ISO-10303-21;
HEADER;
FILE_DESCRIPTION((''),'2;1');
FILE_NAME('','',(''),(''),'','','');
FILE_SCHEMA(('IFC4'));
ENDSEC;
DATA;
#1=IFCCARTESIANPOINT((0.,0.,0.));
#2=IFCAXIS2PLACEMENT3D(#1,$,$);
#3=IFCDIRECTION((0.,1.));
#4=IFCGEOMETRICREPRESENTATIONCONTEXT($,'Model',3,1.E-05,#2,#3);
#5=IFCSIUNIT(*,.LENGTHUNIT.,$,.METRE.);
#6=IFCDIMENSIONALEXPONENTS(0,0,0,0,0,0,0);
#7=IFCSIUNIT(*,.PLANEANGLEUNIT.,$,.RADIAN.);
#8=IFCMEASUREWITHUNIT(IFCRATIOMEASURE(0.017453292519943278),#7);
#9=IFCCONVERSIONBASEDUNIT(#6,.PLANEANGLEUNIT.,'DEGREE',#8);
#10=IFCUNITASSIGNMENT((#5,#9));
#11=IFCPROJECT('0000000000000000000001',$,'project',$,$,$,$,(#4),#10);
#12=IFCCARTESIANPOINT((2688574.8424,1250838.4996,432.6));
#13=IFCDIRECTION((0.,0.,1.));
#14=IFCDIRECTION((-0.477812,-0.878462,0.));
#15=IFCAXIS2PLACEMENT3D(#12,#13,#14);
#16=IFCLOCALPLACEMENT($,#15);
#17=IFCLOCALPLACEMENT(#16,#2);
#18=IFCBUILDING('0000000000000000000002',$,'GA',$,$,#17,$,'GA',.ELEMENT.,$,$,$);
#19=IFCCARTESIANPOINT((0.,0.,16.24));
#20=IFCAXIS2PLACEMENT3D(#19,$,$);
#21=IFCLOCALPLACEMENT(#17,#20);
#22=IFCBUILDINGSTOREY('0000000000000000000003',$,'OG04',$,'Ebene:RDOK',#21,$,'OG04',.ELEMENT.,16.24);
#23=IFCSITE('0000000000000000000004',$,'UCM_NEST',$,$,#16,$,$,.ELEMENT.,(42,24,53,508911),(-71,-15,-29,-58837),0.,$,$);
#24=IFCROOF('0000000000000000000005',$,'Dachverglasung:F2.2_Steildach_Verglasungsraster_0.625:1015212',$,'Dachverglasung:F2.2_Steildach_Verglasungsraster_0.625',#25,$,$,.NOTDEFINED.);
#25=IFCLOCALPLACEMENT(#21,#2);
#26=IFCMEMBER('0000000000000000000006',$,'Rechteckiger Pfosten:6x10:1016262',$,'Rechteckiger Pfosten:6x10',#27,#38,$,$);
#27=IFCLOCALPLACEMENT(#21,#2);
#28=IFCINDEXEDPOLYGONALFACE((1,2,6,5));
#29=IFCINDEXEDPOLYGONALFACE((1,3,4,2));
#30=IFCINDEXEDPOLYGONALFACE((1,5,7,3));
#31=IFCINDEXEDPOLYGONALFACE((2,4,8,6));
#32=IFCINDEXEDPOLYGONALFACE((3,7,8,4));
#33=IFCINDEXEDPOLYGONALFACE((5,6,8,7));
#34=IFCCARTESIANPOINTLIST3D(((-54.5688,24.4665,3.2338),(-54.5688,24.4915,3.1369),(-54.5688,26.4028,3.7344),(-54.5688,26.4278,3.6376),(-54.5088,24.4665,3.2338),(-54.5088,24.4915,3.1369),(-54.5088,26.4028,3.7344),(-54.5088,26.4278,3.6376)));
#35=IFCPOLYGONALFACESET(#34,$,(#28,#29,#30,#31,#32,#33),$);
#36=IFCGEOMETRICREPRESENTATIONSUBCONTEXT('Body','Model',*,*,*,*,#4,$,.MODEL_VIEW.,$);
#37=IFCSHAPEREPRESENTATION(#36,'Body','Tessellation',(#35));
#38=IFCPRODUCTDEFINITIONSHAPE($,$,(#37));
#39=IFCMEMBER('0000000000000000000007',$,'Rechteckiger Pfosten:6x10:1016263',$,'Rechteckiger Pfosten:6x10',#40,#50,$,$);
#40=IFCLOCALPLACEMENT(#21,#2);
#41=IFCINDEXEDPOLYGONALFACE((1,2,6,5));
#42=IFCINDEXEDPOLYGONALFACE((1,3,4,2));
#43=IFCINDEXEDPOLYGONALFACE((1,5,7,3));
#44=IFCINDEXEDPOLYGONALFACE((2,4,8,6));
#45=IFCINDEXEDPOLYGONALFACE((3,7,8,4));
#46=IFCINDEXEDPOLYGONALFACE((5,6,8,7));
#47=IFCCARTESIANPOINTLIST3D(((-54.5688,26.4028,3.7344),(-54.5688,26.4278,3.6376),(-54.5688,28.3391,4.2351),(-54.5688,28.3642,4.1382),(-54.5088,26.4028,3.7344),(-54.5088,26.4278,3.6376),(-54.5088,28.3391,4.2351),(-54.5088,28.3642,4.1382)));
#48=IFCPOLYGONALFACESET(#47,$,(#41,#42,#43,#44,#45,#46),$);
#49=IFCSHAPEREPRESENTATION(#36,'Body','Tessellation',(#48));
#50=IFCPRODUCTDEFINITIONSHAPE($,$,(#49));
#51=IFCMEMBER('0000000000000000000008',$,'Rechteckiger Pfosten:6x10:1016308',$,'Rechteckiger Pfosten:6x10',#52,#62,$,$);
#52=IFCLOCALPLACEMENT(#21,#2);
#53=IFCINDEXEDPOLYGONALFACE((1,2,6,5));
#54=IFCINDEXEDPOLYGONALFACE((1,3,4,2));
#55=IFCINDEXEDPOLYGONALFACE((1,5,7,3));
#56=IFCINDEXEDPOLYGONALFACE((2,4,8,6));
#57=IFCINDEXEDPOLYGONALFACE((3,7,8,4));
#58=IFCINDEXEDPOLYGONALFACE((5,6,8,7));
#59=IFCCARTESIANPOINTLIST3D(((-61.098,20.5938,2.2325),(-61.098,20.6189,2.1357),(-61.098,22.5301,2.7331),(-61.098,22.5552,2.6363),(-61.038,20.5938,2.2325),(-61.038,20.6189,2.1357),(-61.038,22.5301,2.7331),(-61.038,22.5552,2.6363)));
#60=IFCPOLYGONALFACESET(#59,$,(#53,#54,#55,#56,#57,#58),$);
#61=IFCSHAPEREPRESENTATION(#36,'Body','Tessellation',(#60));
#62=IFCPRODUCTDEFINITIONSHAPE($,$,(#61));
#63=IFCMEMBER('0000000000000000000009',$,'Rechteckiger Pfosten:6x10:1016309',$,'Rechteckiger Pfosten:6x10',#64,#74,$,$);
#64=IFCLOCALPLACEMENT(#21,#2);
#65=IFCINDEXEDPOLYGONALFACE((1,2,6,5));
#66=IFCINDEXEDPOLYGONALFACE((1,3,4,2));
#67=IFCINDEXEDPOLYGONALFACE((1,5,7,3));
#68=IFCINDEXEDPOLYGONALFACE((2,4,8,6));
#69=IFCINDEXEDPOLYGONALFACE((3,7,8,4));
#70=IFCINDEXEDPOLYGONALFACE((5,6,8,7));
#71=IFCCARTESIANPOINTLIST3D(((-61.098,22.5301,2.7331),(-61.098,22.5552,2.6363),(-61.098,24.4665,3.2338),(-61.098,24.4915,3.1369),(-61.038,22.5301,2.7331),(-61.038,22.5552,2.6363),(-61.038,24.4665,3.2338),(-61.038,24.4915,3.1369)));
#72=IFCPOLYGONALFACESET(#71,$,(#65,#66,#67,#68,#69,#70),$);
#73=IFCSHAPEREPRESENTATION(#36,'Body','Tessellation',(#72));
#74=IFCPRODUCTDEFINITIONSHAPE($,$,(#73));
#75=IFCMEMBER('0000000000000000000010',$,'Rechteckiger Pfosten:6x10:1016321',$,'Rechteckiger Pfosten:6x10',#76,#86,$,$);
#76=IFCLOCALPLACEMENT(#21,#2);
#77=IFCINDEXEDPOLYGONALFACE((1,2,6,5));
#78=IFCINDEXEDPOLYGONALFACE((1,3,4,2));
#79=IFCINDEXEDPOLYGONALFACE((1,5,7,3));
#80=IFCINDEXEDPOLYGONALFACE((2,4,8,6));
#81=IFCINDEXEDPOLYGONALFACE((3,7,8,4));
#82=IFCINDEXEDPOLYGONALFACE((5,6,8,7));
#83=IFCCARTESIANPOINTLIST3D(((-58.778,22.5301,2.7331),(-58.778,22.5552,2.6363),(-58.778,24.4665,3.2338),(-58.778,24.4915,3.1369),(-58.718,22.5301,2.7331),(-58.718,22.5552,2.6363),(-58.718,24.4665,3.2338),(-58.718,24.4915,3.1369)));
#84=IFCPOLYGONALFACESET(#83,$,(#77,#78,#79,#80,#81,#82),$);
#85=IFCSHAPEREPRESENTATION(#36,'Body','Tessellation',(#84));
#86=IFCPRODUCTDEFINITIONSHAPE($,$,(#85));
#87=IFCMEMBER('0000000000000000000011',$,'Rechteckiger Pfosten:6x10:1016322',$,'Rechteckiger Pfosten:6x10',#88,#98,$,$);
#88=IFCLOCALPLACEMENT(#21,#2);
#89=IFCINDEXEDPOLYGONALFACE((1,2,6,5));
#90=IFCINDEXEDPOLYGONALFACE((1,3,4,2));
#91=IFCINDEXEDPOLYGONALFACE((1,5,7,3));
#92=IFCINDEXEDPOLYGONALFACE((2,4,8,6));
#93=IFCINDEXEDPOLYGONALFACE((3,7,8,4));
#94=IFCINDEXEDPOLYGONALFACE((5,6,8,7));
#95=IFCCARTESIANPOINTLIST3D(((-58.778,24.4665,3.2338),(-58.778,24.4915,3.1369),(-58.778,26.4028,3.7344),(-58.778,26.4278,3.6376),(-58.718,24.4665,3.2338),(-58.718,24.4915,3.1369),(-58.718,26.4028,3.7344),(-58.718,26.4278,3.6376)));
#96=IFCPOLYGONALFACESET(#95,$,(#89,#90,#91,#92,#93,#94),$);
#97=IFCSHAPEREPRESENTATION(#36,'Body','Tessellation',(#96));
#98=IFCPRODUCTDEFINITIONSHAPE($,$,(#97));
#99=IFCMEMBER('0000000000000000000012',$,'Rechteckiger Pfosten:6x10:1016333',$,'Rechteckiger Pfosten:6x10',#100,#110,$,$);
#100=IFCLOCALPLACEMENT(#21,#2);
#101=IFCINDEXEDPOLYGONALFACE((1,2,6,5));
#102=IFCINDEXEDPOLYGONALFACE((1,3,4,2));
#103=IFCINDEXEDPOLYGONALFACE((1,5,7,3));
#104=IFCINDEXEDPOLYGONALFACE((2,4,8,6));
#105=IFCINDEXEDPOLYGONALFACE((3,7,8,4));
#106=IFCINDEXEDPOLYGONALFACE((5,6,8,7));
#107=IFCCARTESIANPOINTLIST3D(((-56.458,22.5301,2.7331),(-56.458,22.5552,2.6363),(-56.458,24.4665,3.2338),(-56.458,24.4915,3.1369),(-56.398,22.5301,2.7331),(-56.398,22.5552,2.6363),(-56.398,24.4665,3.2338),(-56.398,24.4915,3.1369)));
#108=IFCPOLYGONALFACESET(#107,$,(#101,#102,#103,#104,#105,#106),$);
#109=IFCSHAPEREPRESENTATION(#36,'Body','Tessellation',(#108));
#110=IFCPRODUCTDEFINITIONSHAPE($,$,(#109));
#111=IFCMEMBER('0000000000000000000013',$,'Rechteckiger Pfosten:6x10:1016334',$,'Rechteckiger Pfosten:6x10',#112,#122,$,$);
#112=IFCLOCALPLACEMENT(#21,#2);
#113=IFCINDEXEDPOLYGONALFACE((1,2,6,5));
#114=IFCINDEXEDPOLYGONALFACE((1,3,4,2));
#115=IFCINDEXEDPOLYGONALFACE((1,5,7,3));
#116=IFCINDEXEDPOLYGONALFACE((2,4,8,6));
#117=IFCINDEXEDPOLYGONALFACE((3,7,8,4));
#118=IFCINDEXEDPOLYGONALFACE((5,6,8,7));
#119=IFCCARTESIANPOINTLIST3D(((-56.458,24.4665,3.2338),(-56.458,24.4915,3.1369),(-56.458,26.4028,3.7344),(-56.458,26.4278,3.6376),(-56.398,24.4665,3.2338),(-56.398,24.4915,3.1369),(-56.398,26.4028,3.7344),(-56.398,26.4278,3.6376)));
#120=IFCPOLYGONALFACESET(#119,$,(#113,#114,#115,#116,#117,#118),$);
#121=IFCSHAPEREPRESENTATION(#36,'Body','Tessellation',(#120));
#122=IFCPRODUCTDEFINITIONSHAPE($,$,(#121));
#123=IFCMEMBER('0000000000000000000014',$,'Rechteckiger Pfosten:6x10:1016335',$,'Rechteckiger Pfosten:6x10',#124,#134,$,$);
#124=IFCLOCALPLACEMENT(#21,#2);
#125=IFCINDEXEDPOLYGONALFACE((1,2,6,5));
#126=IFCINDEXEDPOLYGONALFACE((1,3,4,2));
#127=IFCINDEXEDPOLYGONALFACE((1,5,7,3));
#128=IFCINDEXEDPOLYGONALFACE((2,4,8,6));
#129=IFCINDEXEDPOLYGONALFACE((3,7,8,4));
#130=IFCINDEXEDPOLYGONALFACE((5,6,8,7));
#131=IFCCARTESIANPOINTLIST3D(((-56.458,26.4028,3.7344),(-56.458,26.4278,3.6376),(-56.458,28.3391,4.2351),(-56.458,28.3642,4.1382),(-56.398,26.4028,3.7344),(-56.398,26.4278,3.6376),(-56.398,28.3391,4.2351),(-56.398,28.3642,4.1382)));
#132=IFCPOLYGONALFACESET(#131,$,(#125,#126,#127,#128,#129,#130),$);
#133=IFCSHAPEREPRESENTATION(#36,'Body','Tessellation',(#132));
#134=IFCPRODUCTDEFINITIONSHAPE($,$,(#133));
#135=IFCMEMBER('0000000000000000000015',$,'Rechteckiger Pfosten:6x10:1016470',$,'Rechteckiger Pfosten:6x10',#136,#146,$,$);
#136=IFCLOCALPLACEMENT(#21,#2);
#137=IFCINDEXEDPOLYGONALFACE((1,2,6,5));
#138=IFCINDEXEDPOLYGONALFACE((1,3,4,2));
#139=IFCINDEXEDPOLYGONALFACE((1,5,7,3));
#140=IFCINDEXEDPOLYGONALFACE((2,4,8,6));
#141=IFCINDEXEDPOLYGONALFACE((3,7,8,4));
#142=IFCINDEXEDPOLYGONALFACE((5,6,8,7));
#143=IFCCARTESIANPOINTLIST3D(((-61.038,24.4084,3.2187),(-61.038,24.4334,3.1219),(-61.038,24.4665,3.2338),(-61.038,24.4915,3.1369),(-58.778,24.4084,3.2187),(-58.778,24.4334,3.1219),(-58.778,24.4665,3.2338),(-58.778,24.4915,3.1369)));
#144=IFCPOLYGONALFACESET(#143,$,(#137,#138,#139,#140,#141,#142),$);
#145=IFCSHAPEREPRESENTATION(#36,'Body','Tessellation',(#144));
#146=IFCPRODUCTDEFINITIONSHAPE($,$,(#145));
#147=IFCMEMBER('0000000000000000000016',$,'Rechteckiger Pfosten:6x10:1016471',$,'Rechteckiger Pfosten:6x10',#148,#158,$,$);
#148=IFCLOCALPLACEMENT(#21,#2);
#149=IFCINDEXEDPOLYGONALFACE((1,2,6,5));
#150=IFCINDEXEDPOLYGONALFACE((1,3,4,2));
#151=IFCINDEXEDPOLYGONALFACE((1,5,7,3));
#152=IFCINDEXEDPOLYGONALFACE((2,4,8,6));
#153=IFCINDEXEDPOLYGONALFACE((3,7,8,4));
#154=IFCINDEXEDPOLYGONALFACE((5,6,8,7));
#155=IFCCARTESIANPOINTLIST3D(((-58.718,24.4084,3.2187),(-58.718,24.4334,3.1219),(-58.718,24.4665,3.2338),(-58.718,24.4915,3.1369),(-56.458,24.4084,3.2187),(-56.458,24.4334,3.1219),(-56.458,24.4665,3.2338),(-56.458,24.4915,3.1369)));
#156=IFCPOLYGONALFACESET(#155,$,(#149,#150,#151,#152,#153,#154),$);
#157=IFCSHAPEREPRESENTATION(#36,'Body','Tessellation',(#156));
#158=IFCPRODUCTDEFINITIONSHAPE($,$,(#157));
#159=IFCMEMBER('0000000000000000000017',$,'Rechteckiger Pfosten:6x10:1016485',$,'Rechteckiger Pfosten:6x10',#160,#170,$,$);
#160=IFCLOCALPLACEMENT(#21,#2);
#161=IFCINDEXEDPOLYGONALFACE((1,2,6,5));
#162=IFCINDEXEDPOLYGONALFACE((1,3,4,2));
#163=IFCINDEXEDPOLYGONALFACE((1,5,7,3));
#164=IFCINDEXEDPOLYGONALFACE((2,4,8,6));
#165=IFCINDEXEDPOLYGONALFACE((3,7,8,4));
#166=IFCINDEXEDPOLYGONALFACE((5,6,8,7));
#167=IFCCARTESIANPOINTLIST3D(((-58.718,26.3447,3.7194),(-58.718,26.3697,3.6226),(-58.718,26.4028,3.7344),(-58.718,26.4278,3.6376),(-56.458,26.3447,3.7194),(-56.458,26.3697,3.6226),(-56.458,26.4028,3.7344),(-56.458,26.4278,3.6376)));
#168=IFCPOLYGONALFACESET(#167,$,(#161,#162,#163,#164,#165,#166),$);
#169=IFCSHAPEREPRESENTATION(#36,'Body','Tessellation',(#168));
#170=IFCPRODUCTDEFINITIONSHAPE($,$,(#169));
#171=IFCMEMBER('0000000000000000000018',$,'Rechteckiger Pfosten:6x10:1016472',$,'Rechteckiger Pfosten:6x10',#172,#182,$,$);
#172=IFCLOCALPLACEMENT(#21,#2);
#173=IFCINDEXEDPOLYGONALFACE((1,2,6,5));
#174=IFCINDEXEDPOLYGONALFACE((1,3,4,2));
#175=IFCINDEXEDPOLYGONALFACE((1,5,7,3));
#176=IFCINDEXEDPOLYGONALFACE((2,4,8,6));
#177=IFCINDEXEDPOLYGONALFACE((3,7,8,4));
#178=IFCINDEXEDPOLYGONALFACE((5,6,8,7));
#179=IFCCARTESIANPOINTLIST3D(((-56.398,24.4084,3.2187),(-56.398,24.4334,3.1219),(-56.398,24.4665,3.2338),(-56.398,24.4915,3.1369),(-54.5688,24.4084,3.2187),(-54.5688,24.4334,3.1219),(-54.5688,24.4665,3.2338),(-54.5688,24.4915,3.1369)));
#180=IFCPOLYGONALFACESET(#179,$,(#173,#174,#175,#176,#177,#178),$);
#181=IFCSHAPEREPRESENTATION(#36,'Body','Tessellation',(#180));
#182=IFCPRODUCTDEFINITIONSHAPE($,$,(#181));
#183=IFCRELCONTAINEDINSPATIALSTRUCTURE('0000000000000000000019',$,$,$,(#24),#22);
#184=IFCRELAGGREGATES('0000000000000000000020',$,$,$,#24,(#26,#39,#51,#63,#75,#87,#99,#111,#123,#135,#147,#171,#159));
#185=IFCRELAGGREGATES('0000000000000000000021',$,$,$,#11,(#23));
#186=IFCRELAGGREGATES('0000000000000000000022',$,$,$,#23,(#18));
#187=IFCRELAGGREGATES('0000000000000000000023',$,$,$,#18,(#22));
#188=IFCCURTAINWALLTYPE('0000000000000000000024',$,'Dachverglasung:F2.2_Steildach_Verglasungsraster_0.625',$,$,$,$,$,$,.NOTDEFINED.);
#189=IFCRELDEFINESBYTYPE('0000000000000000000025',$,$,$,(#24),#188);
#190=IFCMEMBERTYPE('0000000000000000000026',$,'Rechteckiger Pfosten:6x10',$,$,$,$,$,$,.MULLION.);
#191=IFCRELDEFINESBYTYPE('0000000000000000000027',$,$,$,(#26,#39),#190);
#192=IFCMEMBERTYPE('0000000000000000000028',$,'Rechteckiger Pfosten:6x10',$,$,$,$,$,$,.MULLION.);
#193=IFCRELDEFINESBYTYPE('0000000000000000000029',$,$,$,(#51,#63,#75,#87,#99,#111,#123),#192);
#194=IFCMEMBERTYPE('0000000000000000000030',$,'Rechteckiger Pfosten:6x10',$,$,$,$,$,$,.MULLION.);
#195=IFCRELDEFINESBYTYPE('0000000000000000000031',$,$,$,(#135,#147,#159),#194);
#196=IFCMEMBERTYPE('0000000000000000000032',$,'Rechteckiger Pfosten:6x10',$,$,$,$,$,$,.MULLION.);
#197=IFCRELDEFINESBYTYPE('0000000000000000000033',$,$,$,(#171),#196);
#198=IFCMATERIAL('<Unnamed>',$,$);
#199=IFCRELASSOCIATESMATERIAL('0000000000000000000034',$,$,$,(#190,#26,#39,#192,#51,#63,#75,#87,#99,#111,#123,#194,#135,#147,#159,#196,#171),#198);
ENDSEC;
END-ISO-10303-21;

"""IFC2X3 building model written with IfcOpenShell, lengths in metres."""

from ifc_helpers import new_model, entity, si_unit, converted_unit, direction, frame, origin, origin_2d_with_axis, place, context, subcontext, project, spatial, rectangle, extrude, source, transform, mapped, material, type_object, type_shapes, element, aggregate, save


model = new_model("IFC2X3")

# Units and contexts
model_context = context("Model", 3, precision=1e-05, world=origin(), true_north=direction((0.0, 1.0)))
body_context = subcontext(model_context, "Body", "Model", "MODEL_VIEW")
ifc_project = project(units=[si_unit("LENGTHUNIT", "METRE"), converted_unit("PLANEANGLEUNIT", "DEGREE", entity("IfcRatioMeasure", 0.017453292519943278), si_unit("PLANEANGLEUNIT", "RADIAN"), dimensions=[0, 0, 0, 0, 0, 0, 0])], contexts=[model_context])

# Site, building, storey
site_placement = place(None, frame((2688574.8424, 1250838.4996, 432.6), z_axis=(0.0, 0.0, 1.0), x_axis=(-0.477812, -0.878462, 0.0)))
site = spatial("IfcSite", under=ifc_project, at=site_placement, Name="UCM_NEST", CompositionType="ELEMENT", RefLatitude=(42, 24, 53, 508911), RefLongitude=(-71, -15, -29, -58837), RefElevation=0.0)
building_placement = place(site_placement, origin())
building = spatial("IfcBuilding", under=site, at=building_placement, Name="GA", LongName="GA", CompositionType="ELEMENT")
storey_placement = place(building_placement, frame((0.0, 0.0, 16.24)))
storey = spatial("IfcBuildingStorey", under=building, at=storey_placement, Name="OG04", ObjectType="Ebene:RDOK", LongName="OG04", CompositionType="ELEMENT", Elevation=16.24)

# Roof, members
curtain_wall_type = type_object("IfcCurtainWallType", Name="Dachverglasung:F2.2_Steildach_Verglasungsraster_0.625", PredefinedType="NOTDEFINED")
roof_placement = place(storey_placement, frame((0.0, 0.0, -16.24)))
roof = element("IfcRoof", 1, at=roof_placement, inside=storey, type_object=curtain_wall_type, Name="Dachverglasung:F2.2_Steildach_Verglasungsraster_0.625:1015212", ObjectType="Dachverglasung:F2.2_Steildach_Verglasungsraster_0.625", ShapeType="NOTDEFINED")
ifc_material_1 = material(Name="<Unnamed>")
member_type_1 = type_object("IfcMemberType", Name="Rechteckiger Pfosten:6x10", PredefinedType="MULLION", material=ifc_material_1)
shared_shape_1 = source(origin(), body_context, "Body", "SweptSolid", [
    extrude(rectangle(XDim=0.1, YDim=0.06, at=origin_2d_with_axis()), frame((-0.03, -0.05, -2.0), z_axis=(0.0, 0.0, 1.0), x_axis=(0.0, -1.0, 0.0)), (0.0, 0.0, 1.0), 2.0),
])
type_shapes(member_type_1, [shared_shape_1])
member_1_placement = place(roof_placement, frame((-54.5088, 26.4278, 19.8776), z_axis=(0.0, 0.968163, 0.250322), x_axis=(1.0, 0.0, 0.0)))
member_1 = element("IfcMember", 2, at=member_1_placement, type_object=member_type_1, material=ifc_material_1, Name="Rechteckiger Pfosten:6x10:1016262", ObjectType="Rechteckiger Pfosten:6x10", context=body_context, shape_type="MappedRepresentation", body=[
    mapped(shared_shape_1, transform((0.0, 0.0, 0.0), scale=1.0)),
])
member_2_placement = place(roof_placement, frame((-54.5088, 28.3642, 20.3782), z_axis=(0.0, 0.968163, 0.250322), x_axis=(1.0, 0.0, 0.0)))
member_2 = element("IfcMember", 3, at=member_2_placement, type_object=member_type_1, material=ifc_material_1, Name="Rechteckiger Pfosten:6x10:1016263", ObjectType="Rechteckiger Pfosten:6x10", context=body_context, shape_type="MappedRepresentation", body=[
    mapped(shared_shape_1, transform((0.0, 0.0, 0.0), scale=1.0)),
])
member_type_2 = type_object("IfcMemberType", Name="Rechteckiger Pfosten:6x10", PredefinedType="MULLION", material=ifc_material_1)
shared_shape_2 = source(origin(), body_context, "Body", "SweptSolid", [
    extrude(rectangle(XDim=0.1, YDim=0.06, at=origin_2d_with_axis()), frame((-0.03, -0.05, -2.0), z_axis=(0.0, 0.0, 1.0), x_axis=(0.0, -1.0, 0.0)), (0.0, 0.0, 1.0), 2.0),
])
type_shapes(member_type_2, [shared_shape_2])
member_3_placement = place(roof_placement, frame((-61.038, 22.5552, 18.8763), z_axis=(0.0, 0.968163, 0.250322), x_axis=(1.0, 0.0, 0.0)))
member_3 = element("IfcMember", 4, at=member_3_placement, type_object=member_type_2, material=ifc_material_1, Name="Rechteckiger Pfosten:6x10:1016308", ObjectType="Rechteckiger Pfosten:6x10", context=body_context, shape_type="MappedRepresentation", body=[
    mapped(shared_shape_2, transform((0.0, 0.0, 0.0), scale=1.0)),
])
member_4_placement = place(roof_placement, frame((-61.038, 24.4915, 19.3769), z_axis=(0.0, 0.968163, 0.250322), x_axis=(1.0, 0.0, 0.0)))
member_4 = element("IfcMember", 5, at=member_4_placement, type_object=member_type_2, material=ifc_material_1, Name="Rechteckiger Pfosten:6x10:1016309", ObjectType="Rechteckiger Pfosten:6x10", context=body_context, shape_type="MappedRepresentation", body=[
    mapped(shared_shape_2, transform((0.0, 0.0, 0.0), scale=1.0)),
])
member_5_placement = place(roof_placement, frame((-58.718, 24.4915, 19.3769), z_axis=(0.0, 0.968163, 0.250322), x_axis=(1.0, 0.0, 0.0)))
member_5 = element("IfcMember", 6, at=member_5_placement, type_object=member_type_2, material=ifc_material_1, Name="Rechteckiger Pfosten:6x10:1016321", ObjectType="Rechteckiger Pfosten:6x10", context=body_context, shape_type="MappedRepresentation", body=[
    mapped(shared_shape_2, transform((0.0, 0.0, 0.0), scale=1.0)),
])
member_6_placement = place(roof_placement, frame((-58.718, 26.4278, 19.8776), z_axis=(0.0, 0.968163, 0.250322), x_axis=(1.0, 0.0, 0.0)))
member_6 = element("IfcMember", 7, at=member_6_placement, type_object=member_type_2, material=ifc_material_1, Name="Rechteckiger Pfosten:6x10:1016322", ObjectType="Rechteckiger Pfosten:6x10", context=body_context, shape_type="MappedRepresentation", body=[
    mapped(shared_shape_2, transform((0.0, 0.0, 0.0), scale=1.0)),
])
member_7_placement = place(roof_placement, frame((-56.398, 24.4915, 19.3769), z_axis=(0.0, 0.968163, 0.250322), x_axis=(1.0, 0.0, 0.0)))
member_7 = element("IfcMember", 8, at=member_7_placement, type_object=member_type_2, material=ifc_material_1, Name="Rechteckiger Pfosten:6x10:1016333", ObjectType="Rechteckiger Pfosten:6x10", context=body_context, shape_type="MappedRepresentation", body=[
    mapped(shared_shape_2, transform((0.0, 0.0, 0.0), scale=1.0)),
])
member_8_placement = place(roof_placement, frame((-56.398, 26.4278, 19.8776), z_axis=(0.0, 0.968163, 0.250322), x_axis=(1.0, 0.0, 0.0)))
member_8 = element("IfcMember", 9, at=member_8_placement, type_object=member_type_2, material=ifc_material_1, Name="Rechteckiger Pfosten:6x10:1016334", ObjectType="Rechteckiger Pfosten:6x10", context=body_context, shape_type="MappedRepresentation", body=[
    mapped(shared_shape_2, transform((0.0, 0.0, 0.0), scale=1.0)),
])
member_9_placement = place(roof_placement, frame((-56.398, 28.3642, 20.3782), z_axis=(0.0, 0.968163, 0.250322), x_axis=(1.0, 0.0, 0.0)))
member_9 = element("IfcMember", 10, at=member_9_placement, type_object=member_type_2, material=ifc_material_1, Name="Rechteckiger Pfosten:6x10:1016335", ObjectType="Rechteckiger Pfosten:6x10", context=body_context, shape_type="MappedRepresentation", body=[
    mapped(shared_shape_2, transform((0.0, 0.0, 0.0), scale=1.0)),
])
member_type_3 = type_object("IfcMemberType", Name="Rechteckiger Pfosten:6x10", PredefinedType="MULLION", material=ifc_material_1)
shared_shape_3 = source(origin(), body_context, "Body", "SweptSolid", [
    extrude(rectangle(XDim=0.1, YDim=0.06, at=origin_2d_with_axis()), frame((-0.03, -0.05, -2.26), z_axis=(0.0, 0.0, 1.0), x_axis=(0.0, -1.0, 0.0)), (0.0, 0.0, 1.0), 2.26),
])
type_shapes(member_type_3, [shared_shape_3])
member_10_placement = place(roof_placement, frame((-61.038, 24.4915, 19.3769), z_axis=(-1.0, 0.0, 0.0), x_axis=(0.0, 0.968163, 0.250322)))
member_10 = element("IfcMember", 11, at=member_10_placement, type_object=member_type_3, material=ifc_material_1, Name="Rechteckiger Pfosten:6x10:1016470", ObjectType="Rechteckiger Pfosten:6x10", context=body_context, shape_type="MappedRepresentation", body=[
    mapped(shared_shape_3, transform((0.0, 0.0, 0.0), scale=1.0)),
])
member_11_placement = place(roof_placement, frame((-58.718, 24.4915, 19.3769), z_axis=(-1.0, 0.0, 0.0), x_axis=(0.0, 0.968163, 0.250322)))
member_11 = element("IfcMember", 12, at=member_11_placement, type_object=member_type_3, material=ifc_material_1, Name="Rechteckiger Pfosten:6x10:1016471", ObjectType="Rechteckiger Pfosten:6x10", context=body_context, shape_type="MappedRepresentation", body=[
    mapped(shared_shape_3, transform((0.0, 0.0, 0.0), scale=1.0)),
])
member_12_placement = place(roof_placement, frame((-58.718, 26.4278, 19.8776), z_axis=(-1.0, 0.0, 0.0), x_axis=(0.0, 0.968163, 0.250322)))
member_12 = element("IfcMember", 13, at=member_12_placement, type_object=member_type_3, material=ifc_material_1, Name="Rechteckiger Pfosten:6x10:1016485", ObjectType="Rechteckiger Pfosten:6x10", context=body_context, shape_type="MappedRepresentation", body=[
    mapped(shared_shape_3, transform((0.0, 0.0, 0.0), scale=1.0)),
])
member_type_4 = type_object("IfcMemberType", Name="Rechteckiger Pfosten:6x10", PredefinedType="MULLION", material=ifc_material_1)
shared_shape_4 = source(origin(), body_context, "Body", "SweptSolid", [
    extrude(rectangle(XDim=0.1, YDim=0.06, at=origin_2d_with_axis()), frame((-0.03, -0.05, -1.8292), z_axis=(0.0, 0.0, 1.0), x_axis=(0.0, -1.0, 0.0)), (0.0, 0.0, 1.0), 1.8292),
])
type_shapes(member_type_4, [shared_shape_4])
member_13_placement = place(roof_placement, frame((-56.398, 24.4915, 19.3769), z_axis=(-1.0, 0.0, 0.0), x_axis=(0.0, 0.968163, 0.250322)))
member_13 = element("IfcMember", 14, at=member_13_placement, type_object=member_type_4, material=ifc_material_1, Name="Rechteckiger Pfosten:6x10:1016472", ObjectType="Rechteckiger Pfosten:6x10", context=body_context, shape_type="MappedRepresentation", body=[
    mapped(shared_shape_4, transform((0.0, 0.0, 0.0), scale=1.0)),
])
aggregate(roof, [member_1, member_2, member_3, member_4, member_5, member_6, member_7, member_8, member_9, member_10, member_11, member_13, member_12])

save(model, "model.ifc")
